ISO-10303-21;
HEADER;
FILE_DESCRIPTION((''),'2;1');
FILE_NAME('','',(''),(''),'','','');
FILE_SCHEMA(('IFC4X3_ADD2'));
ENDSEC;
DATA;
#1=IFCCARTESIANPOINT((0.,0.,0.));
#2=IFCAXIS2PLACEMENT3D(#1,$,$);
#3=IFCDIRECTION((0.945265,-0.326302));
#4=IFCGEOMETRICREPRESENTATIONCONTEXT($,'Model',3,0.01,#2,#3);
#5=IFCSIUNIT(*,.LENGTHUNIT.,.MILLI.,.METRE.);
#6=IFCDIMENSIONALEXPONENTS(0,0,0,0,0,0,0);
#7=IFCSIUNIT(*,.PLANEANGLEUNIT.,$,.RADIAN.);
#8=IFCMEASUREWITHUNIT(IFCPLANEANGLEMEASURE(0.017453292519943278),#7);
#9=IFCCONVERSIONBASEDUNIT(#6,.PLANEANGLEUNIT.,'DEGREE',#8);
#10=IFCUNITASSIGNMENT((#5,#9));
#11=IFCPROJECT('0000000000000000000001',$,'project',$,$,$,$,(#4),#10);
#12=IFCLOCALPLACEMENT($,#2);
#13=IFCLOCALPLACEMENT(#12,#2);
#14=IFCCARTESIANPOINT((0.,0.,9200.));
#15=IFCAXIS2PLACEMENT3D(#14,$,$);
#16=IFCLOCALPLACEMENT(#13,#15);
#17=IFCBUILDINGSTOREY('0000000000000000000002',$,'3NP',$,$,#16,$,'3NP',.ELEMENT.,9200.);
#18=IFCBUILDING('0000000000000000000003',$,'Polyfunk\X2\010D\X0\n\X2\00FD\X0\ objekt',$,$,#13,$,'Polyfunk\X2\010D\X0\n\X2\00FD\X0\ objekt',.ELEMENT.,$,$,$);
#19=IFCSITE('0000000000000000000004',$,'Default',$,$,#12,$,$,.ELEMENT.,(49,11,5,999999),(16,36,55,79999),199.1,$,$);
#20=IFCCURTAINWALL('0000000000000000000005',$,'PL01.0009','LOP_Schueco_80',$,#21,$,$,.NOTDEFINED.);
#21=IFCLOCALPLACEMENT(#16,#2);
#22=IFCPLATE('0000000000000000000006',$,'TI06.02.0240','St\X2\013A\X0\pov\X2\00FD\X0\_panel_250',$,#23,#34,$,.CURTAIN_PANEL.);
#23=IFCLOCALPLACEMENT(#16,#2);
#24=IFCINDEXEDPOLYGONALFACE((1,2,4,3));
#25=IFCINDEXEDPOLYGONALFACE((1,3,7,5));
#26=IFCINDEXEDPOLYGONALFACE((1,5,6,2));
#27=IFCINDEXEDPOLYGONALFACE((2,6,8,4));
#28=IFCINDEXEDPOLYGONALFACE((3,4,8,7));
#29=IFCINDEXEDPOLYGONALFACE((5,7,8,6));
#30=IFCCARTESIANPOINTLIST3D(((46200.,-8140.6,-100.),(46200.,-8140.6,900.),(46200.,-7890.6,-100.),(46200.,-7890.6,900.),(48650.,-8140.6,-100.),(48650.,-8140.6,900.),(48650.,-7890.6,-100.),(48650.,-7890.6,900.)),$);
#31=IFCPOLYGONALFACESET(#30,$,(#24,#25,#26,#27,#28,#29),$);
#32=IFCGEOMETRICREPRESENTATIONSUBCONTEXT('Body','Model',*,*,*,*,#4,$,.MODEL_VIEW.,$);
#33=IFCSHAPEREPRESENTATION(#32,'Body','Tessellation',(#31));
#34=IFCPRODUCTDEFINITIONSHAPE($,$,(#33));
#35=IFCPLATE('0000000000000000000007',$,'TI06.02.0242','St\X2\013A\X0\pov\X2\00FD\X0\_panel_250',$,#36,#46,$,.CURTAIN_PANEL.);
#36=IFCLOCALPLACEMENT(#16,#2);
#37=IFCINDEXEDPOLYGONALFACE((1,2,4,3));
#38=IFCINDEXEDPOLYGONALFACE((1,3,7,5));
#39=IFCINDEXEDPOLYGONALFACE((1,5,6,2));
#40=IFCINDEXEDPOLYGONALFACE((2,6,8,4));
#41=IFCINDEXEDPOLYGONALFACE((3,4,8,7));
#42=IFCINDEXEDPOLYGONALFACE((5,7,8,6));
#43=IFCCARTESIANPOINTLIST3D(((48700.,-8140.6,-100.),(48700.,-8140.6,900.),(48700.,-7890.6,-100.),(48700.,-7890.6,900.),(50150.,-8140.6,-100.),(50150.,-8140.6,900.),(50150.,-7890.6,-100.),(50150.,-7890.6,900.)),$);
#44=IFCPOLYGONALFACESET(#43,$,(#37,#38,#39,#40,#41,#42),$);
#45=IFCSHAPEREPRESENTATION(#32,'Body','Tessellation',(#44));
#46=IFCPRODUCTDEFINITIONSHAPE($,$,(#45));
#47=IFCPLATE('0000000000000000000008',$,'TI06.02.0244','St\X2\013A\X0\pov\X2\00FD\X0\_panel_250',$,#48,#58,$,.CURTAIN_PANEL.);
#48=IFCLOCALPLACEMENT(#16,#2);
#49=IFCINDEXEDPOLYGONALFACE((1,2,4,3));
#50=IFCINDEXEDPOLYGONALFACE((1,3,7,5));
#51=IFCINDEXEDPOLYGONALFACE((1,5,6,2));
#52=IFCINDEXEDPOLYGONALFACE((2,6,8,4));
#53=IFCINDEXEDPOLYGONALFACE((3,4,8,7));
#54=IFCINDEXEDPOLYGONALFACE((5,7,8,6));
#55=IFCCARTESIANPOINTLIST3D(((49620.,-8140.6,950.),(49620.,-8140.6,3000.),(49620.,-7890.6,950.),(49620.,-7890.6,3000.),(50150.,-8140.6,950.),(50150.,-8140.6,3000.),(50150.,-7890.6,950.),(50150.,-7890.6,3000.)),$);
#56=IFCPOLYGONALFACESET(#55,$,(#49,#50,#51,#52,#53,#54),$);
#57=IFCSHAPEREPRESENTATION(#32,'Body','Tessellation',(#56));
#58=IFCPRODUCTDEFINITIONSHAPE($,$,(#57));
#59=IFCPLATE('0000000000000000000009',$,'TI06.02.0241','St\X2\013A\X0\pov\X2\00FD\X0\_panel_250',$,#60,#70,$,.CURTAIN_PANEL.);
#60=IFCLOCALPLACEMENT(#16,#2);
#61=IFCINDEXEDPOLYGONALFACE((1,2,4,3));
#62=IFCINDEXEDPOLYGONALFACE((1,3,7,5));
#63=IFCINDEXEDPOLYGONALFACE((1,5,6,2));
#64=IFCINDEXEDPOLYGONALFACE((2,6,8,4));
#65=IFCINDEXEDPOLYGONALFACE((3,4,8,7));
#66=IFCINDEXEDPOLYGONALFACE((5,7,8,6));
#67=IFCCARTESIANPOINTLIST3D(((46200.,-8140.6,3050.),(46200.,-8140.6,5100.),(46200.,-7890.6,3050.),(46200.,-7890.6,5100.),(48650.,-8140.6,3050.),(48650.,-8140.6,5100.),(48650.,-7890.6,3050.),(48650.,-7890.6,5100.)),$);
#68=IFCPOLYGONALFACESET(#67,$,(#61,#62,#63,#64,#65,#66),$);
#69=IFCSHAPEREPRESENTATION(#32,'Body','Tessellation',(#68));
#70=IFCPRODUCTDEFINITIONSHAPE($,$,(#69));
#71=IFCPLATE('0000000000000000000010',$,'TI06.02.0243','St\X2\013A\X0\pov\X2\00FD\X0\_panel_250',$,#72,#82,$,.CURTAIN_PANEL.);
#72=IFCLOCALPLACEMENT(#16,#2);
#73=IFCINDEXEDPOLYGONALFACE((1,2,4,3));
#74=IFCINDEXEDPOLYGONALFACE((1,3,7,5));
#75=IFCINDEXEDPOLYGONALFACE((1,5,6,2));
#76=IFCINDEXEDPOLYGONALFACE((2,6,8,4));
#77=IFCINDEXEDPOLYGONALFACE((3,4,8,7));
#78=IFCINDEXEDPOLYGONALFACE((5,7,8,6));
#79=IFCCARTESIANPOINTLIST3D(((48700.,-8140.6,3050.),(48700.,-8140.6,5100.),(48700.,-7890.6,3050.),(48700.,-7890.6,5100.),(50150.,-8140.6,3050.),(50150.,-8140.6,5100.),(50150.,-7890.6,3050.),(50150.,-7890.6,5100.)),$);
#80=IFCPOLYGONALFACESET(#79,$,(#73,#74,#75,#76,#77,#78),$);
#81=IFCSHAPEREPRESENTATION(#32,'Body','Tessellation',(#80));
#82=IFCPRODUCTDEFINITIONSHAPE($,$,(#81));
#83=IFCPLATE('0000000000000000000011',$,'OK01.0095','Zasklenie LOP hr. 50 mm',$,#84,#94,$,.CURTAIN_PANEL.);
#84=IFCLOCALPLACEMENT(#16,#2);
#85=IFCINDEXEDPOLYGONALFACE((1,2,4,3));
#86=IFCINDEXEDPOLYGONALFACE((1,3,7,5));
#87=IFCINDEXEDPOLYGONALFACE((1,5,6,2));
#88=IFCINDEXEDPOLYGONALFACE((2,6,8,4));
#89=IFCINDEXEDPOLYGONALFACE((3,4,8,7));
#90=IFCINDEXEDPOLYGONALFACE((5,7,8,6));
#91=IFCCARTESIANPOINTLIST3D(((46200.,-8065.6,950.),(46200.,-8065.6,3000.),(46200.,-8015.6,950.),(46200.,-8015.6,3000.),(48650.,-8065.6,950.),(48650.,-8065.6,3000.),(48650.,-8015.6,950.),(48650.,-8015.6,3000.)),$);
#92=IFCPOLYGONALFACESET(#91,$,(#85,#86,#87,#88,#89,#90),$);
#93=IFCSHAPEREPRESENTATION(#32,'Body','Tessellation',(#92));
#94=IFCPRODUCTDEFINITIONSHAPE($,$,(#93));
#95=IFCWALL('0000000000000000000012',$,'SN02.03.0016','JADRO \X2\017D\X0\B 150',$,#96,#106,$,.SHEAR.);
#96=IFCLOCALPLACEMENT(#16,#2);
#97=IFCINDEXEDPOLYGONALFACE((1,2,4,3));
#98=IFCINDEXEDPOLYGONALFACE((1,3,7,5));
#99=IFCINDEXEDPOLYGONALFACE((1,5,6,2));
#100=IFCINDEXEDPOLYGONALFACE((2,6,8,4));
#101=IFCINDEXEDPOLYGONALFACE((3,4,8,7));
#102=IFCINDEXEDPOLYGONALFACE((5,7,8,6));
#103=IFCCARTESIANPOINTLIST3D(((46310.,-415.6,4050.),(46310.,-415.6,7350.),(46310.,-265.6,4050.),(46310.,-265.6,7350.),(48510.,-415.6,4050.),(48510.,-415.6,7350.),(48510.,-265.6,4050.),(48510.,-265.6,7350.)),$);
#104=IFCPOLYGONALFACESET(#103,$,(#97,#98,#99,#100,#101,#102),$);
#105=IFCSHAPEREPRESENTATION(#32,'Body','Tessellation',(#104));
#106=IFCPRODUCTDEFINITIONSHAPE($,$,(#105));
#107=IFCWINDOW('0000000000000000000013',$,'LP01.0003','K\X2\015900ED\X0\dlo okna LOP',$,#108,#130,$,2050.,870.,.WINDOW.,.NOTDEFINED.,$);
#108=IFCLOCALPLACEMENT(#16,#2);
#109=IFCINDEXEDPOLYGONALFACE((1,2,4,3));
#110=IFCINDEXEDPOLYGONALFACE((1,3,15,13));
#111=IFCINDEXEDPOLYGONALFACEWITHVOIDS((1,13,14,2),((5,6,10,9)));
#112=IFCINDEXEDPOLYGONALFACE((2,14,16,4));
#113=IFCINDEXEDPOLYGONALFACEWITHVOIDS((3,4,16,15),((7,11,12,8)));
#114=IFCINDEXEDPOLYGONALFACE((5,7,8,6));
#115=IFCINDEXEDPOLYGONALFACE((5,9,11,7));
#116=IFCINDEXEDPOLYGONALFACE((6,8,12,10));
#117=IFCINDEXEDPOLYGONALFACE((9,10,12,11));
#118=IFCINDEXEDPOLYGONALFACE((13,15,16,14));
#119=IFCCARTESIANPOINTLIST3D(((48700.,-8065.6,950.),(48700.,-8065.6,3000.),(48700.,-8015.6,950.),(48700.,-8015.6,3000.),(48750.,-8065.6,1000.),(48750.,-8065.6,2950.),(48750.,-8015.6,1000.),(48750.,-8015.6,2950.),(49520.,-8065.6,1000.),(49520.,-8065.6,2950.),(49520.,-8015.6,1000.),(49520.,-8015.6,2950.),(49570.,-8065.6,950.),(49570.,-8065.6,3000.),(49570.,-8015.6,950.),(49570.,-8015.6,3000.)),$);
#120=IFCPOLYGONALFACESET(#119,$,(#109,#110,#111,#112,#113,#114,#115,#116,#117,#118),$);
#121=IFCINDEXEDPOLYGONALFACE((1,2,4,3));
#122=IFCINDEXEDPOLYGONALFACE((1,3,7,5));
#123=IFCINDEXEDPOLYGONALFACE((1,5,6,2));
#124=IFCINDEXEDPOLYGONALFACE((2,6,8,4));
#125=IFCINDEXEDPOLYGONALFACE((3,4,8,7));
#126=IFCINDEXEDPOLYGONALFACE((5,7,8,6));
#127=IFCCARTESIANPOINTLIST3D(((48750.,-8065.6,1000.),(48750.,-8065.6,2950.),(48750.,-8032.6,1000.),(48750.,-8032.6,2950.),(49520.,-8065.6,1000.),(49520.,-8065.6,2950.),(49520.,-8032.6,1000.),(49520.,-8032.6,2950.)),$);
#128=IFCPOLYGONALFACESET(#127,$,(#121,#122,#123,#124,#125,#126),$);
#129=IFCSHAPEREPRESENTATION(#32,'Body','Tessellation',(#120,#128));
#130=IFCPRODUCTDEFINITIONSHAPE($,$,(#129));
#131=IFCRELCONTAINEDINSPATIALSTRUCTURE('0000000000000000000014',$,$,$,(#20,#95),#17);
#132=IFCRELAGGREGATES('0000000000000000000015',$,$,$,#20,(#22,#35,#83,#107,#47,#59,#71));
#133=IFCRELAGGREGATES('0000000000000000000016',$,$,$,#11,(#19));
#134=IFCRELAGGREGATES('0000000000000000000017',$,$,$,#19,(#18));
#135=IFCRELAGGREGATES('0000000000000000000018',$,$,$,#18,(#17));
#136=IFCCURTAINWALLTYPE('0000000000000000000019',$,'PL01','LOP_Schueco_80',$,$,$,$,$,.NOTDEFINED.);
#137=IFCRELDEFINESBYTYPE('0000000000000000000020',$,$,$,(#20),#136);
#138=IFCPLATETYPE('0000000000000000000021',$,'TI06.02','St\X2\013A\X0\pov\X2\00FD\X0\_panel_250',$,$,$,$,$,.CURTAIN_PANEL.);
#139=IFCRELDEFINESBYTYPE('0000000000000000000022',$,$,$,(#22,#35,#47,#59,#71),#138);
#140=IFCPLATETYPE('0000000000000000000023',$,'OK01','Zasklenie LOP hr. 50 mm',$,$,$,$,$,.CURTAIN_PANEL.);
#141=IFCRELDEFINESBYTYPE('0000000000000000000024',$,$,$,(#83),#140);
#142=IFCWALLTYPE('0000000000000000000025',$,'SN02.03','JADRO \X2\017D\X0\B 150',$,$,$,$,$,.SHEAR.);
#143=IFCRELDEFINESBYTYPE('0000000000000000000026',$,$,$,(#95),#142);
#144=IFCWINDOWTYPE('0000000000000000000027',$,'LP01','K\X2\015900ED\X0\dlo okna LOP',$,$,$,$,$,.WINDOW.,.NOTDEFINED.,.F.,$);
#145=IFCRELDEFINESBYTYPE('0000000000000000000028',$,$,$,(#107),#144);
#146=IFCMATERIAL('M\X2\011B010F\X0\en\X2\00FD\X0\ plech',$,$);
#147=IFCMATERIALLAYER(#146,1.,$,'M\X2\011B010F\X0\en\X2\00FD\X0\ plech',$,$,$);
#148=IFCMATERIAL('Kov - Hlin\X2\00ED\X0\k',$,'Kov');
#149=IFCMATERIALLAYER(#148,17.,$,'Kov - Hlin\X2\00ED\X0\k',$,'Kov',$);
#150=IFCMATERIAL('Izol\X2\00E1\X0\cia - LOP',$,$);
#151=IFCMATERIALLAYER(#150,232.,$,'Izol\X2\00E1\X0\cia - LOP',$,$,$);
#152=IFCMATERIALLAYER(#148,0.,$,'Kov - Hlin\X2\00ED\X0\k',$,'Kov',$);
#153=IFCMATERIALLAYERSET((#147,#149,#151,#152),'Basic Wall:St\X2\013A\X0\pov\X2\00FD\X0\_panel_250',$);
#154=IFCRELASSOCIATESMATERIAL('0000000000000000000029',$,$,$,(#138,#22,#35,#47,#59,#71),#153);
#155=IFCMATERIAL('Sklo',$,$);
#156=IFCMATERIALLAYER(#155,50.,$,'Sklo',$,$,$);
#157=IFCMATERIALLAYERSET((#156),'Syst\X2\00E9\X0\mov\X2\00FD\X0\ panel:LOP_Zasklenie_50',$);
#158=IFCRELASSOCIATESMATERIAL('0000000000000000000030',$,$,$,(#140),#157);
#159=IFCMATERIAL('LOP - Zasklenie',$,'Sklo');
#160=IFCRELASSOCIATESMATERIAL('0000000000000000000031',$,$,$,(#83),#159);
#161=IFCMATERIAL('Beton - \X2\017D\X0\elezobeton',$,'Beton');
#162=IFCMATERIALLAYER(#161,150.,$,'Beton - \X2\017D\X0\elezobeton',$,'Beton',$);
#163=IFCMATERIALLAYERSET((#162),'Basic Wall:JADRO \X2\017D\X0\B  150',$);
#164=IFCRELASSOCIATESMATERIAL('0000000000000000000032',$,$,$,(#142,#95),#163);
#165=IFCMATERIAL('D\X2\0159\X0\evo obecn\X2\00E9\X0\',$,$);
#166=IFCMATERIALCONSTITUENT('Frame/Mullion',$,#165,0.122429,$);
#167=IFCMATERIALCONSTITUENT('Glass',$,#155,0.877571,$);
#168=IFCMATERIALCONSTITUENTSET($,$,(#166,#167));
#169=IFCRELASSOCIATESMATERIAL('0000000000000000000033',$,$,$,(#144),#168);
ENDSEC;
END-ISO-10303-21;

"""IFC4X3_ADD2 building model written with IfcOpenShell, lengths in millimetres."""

from ifc_helpers import new_model, entity, si_unit, converted_unit, direction, frame, frame_2d, origin, origin_2d_with_axis, place, context, subcontext, project, spatial, polyline, rectangle, outline, extrude, clip, bounded_halfspace, source, transform, mapped, material, layer, layer_set, layer_usage, constituent, constituent_set, type_object, type_shapes, element, aggregate, save


model = new_model("IFC4X3_ADD2")

# Units and contexts
model_context = context("Model", 3, precision=0.01, world=origin(), true_north=direction((0.945265, -0.326302)))
body_context = subcontext(model_context, "Body", "Model", "MODEL_VIEW")
ifc_project = project(units=[si_unit("LENGTHUNIT", "METRE", prefix="MILLI"), converted_unit("PLANEANGLEUNIT", "DEGREE", entity("IfcPlaneAngleMeasure", 0.017453292519943278), si_unit("PLANEANGLEUNIT", "RADIAN"), dimensions=[0, 0, 0, 0, 0, 0, 0])], contexts=[model_context])

# Site, building, storey
site_placement = place(None, origin())
site = spatial("IfcSite", under=ifc_project, at=site_placement, Name="Default", CompositionType="ELEMENT", RefLatitude=(49, 11, 5, 999999), RefLongitude=(16, 36, 55, 79999), RefElevation=199.1)
building_placement = place(site_placement, origin())
building = spatial("IfcBuilding", under=site, at=building_placement, Name="Polyfunkčný objekt", LongName="Polyfunkčný objekt", CompositionType="ELEMENT")
storey_placement = place(building_placement, frame((0.0, 0.0, 9200.0)))
storey = spatial("IfcBuildingStorey", under=building, at=storey_placement, Name="3NP", LongName="3NP", CompositionType="ELEMENT", Elevation=9200.0)

# Curtain wall, plates
curtain_wall_type = type_object("IfcCurtainWallType", Name="PL01", Description="LOP_Schueco_80", PredefinedType="NOTDEFINED")
curtain_wall_placement = place(storey_placement, frame((0.0, 0.0, -9200.0)))
curtain_wall = element("IfcCurtainWall", 1, at=curtain_wall_placement, inside=storey, type_object=curtain_wall_type, Name="PL01.0009", Description="LOP_Schueco_80", PredefinedType="NOTDEFINED")
ifc_material_1 = material(Name="Měďený plech")
ifc_layer_1 = layer(ifc_material_1, 1.0, Name="Měďený plech")
ifc_material_2 = material(Name="Kov - Hliník", Category="Kov")
ifc_layer_2 = layer(ifc_material_2, 17.0, Name="Kov - Hliník", Category="Kov")
ifc_material_3 = material(Name="Izolácia - LOP")
ifc_layer_3 = layer(ifc_material_3, 232.0, Name="Izolácia - LOP")
ifc_layer_4 = layer(ifc_material_2, 0.0, Name="Kov - Hliník", Category="Kov")
ifc_layer_set_1 = layer_set([ifc_layer_1, ifc_layer_2, ifc_layer_3, ifc_layer_4], Name="Basic Wall:Stĺpový_panel_250")
ifc_layer_usage_1 = layer_usage(ifc_layer_set_1, "AXIS2", "POSITIVE", -125.0)
plate_type_1 = type_object("IfcPlateType", Name="TI06.02", Description="Stĺpový_panel_250", PredefinedType="CURTAIN_PANEL", material=ifc_layer_set_1)
plate_1_placement = place(storey_placement, frame((46200.0, -8015.6, -100.0)))
plate_1 = element("IfcPlate", 2, at=plate_1_placement, type_object=plate_type_1, material=ifc_layer_usage_1, Name="TI06.02.0240", Description="Stĺpový_panel_250", PredefinedType="CURTAIN_PANEL", context=body_context, shape_type="SweptSolid", body=[
    extrude(rectangle(XDim=250.0, YDim=2450.0, at=frame_2d((0.0, 0.0), x_axis=(1.0, 0.0))), frame((1225.0, 0.0, 0.0), z_axis=(0.0, 0.0, 1.0), x_axis=(0.0, 1.0, 0.0)), (0.0, 0.0, 1.0), 1000.0),
])
ifc_layer_usage_2 = layer_usage(ifc_layer_set_1, "AXIS2", "POSITIVE", -125.0)
plate_2_placement = place(storey_placement, frame((48700.0, -8015.6, -100.0)))
plate_2 = element("IfcPlate", 3, at=plate_2_placement, type_object=plate_type_1, material=ifc_layer_usage_2, Name="TI06.02.0242", Description="Stĺpový_panel_250", PredefinedType="CURTAIN_PANEL", context=body_context, shape_type="SweptSolid", body=[
    extrude(rectangle(XDim=250.0, YDim=1450.0, at=frame_2d((0.0, 0.0), x_axis=(1.0, 0.0))), frame((725.0, 0.0, 0.0), z_axis=(0.0, 0.0, 1.0), x_axis=(0.0, 1.0, 0.0)), (0.0, 0.0, 1.0), 1000.0),
])
ifc_layer_usage_3 = layer_usage(ifc_layer_set_1, "AXIS2", "POSITIVE", -125.0)
plate_3_placement = place(storey_placement, frame((49620.0, -8015.6, 950.0)))
plate_3 = element("IfcPlate", 4, at=plate_3_placement, type_object=plate_type_1, material=ifc_layer_usage_3, Name="TI06.02.0244", Description="Stĺpový_panel_250", PredefinedType="CURTAIN_PANEL", context=body_context, shape_type="SweptSolid", body=[
    extrude(rectangle(XDim=250.0, YDim=530.0, at=origin_2d_with_axis()), frame((265.0, 0.0, 0.0), z_axis=(0.0, 0.0, 1.0), x_axis=(0.0, 1.0, 0.0)), (0.0, 0.0, 1.0), 2050.0),
])
ifc_layer_usage_4 = layer_usage(ifc_layer_set_1, "AXIS2", "POSITIVE", -125.0)
plate_4_placement = place(storey_placement, frame((46200.0, -8015.6, 3050.0)))
plate_4 = element("IfcPlate", 5, at=plate_4_placement, type_object=plate_type_1, material=ifc_layer_usage_4, Name="TI06.02.0241", Description="Stĺpový_panel_250", PredefinedType="CURTAIN_PANEL", context=body_context, shape_type="SweptSolid", body=[
    extrude(rectangle(XDim=250.0, YDim=2450.0, at=frame_2d((0.0, 0.0), x_axis=(1.0, 0.0))), frame((1225.0, 0.0, 0.0), z_axis=(0.0, 0.0, 1.0), x_axis=(0.0, 1.0, 0.0)), (0.0, 0.0, 1.0), 2050.0),
])
ifc_layer_usage_5 = layer_usage(ifc_layer_set_1, "AXIS2", "POSITIVE", -125.0)
plate_5_placement = place(storey_placement, frame((48700.0, -8015.6, 3050.0)))
plate_5 = element("IfcPlate", 6, at=plate_5_placement, type_object=plate_type_1, material=ifc_layer_usage_5, Name="TI06.02.0243", Description="Stĺpový_panel_250", PredefinedType="CURTAIN_PANEL", context=body_context, shape_type="SweptSolid", body=[
    extrude(rectangle(XDim=250.0, YDim=1450.0, at=frame_2d((0.0, 0.0), x_axis=(1.0, 0.0))), frame((725.0, 0.0, 0.0), z_axis=(0.0, 0.0, 1.0), x_axis=(0.0, 1.0, 0.0)), (0.0, 0.0, 1.0), 2050.0),
])
ifc_material_4 = material(Name="LOP - Zasklenie", Category="Sklo")
ifc_material_5 = material(Name="Sklo")
ifc_layer_5 = layer(ifc_material_5, 50.0, Name="Sklo")
ifc_layer_set_2 = layer_set([ifc_layer_5], Name="Systémový panel:LOP_Zasklenie_50")
plate_type_2 = type_object("IfcPlateType", Name="OK01", Description="Zasklenie LOP hr. 50 mm", PredefinedType="CURTAIN_PANEL", material=ifc_layer_set_2)
shared_shape_1 = source(origin(), body_context, "Body", "SweptSolid", [
    extrude(rectangle(XDim=50.0, YDim=2450.0, at=origin_2d_with_axis()), frame((0.0, -25.0, 0.0), z_axis=(0.0, 0.0, 1.0), x_axis=(0.0, 1.0, 0.0)), (0.0, 0.0, 1.0), 2050.0),
])
type_shapes(plate_type_2, [shared_shape_1])
plate_6_placement = place(curtain_wall_placement, frame((47425.0, -8015.6, 10150.0)))
plate_6 = element("IfcPlate", 7, at=plate_6_placement, type_object=plate_type_2, material=ifc_material_4, Name="OK01.0095", Description="Zasklenie LOP hr. 50 mm", PredefinedType="CURTAIN_PANEL", context=body_context, shape_type="MappedRepresentation", body=[
    mapped(shared_shape_1, transform((0.0, 0.0, 0.0), scale=1.0)),
])

# Wall
ifc_material_6 = material(Name="Beton - Železobeton", Category="Beton")
ifc_layer_6 = layer(ifc_material_6, 150.0, Name="Beton - Železobeton", Category="Beton")
ifc_layer_set_3 = layer_set([ifc_layer_6], Name="Basic Wall:JADRO ŽB  150")
wall_type = type_object("IfcWallType", Name="SN02.03", Description="JADRO ŽB 150", PredefinedType="SHEAR", material=ifc_layer_set_3)
wall_placement = place(storey_placement, frame((46310.0, -340.6, 4050.0)))
element("IfcWall", 8, at=wall_placement, inside=storey, type_object=wall_type, material=ifc_layer_set_3, Name="SN02.03.0016", Description="JADRO ŽB 150", PredefinedType="SHEAR", context=body_context, shape_type="Clipping", body=[
    clip(extrude(rectangle(XDim=2200.0, YDim=150.0, at=frame_2d((1100.0, 0.0), x_axis=(-1.0, 0.0))), origin(), (0.0, 0.0, 1.0), 3300.0), bounded_halfspace(frame((2200.0, -75.0, 0.0), z_axis=(0.0, 0.0, 1.0), x_axis=(-1.0, 0.0, 0.0)), True, frame((2200.0, -75.0, 0.0)), polyline([(0.0, 0.0), (0.0, 150.0), (-2200.0, 150.0), (-2200.0, 0.0), (-150.0, 0.0), (0.0, 0.0)]))),
])

# Window
ifc_material_7 = material(Name="Dřevo obecné")
ifc_constituent_1 = constituent(ifc_material_7, Name="Frame/Mullion", fraction=0.122429)
ifc_constituent_2 = constituent(ifc_material_5, Name="Glass", fraction=0.877571)
ifc_constituent_set = constituent_set(constituents=[ifc_constituent_1, ifc_constituent_2])
window_type = type_object("IfcWindowType", Name="LP01", Description="Křídlo okna LOP", ParameterTakesPrecedence=False, PartitioningType="NOTDEFINED", PredefinedType="WINDOW", material=ifc_constituent_set)
shared_shape_2 = source(origin(), body_context, "Body", "SweptSolid", [
    extrude(outline(polyline([(-1025.0, -435.0), (1025.0, -435.0), (1025.0, 435.0), (-1025.0, 435.0), (-1025.0, -435.0)]), holes=[polyline([(-975.0, -385.0), (-975.0, 385.0), (975.0, 385.0), (975.0, -385.0), (-975.0, -385.0)])]), frame((0.0, 50.0, 1025.0), z_axis=(0.0, -1.0, 0.0), x_axis=(0.0, 0.0, -1.0)), (0.0, 0.0, 1.0), 50.0),
    extrude(rectangle(XDim=770.0, YDim=33.0, at=frame_2d((0.0, 0.0), x_axis=(1.0, 0.0))), frame((0.0, 33.5, 50.0), z_axis=(0.0, 0.0, 1.0), x_axis=(-1.0, 0.0, 0.0)), (0.0, 0.0, 1.0), 1950.0),
])
type_shapes(window_type, [shared_shape_2])
window_placement = place(curtain_wall_placement, frame((49135.0, -8015.6, 10150.0), z_axis=(0.0, 0.0, 1.0), x_axis=(-1.0, 0.0, 0.0)))
window = element("IfcWindow", 9, at=window_placement, type_object=window_type, Name="LP01.0003", Description="Křídlo okna LOP", OverallHeight=2050.0, OverallWidth=870.0, PartitioningType="NOTDEFINED", PredefinedType="WINDOW", context=body_context, shape_type="MappedRepresentation", body=[
    mapped(shared_shape_2, transform((0.0, 0.0, 0.0), scale=1.0)),
])
aggregate(curtain_wall, [plate_1, plate_2, plate_6, window, plate_3, plate_4, plate_5])

save(model, "model.ifc")
